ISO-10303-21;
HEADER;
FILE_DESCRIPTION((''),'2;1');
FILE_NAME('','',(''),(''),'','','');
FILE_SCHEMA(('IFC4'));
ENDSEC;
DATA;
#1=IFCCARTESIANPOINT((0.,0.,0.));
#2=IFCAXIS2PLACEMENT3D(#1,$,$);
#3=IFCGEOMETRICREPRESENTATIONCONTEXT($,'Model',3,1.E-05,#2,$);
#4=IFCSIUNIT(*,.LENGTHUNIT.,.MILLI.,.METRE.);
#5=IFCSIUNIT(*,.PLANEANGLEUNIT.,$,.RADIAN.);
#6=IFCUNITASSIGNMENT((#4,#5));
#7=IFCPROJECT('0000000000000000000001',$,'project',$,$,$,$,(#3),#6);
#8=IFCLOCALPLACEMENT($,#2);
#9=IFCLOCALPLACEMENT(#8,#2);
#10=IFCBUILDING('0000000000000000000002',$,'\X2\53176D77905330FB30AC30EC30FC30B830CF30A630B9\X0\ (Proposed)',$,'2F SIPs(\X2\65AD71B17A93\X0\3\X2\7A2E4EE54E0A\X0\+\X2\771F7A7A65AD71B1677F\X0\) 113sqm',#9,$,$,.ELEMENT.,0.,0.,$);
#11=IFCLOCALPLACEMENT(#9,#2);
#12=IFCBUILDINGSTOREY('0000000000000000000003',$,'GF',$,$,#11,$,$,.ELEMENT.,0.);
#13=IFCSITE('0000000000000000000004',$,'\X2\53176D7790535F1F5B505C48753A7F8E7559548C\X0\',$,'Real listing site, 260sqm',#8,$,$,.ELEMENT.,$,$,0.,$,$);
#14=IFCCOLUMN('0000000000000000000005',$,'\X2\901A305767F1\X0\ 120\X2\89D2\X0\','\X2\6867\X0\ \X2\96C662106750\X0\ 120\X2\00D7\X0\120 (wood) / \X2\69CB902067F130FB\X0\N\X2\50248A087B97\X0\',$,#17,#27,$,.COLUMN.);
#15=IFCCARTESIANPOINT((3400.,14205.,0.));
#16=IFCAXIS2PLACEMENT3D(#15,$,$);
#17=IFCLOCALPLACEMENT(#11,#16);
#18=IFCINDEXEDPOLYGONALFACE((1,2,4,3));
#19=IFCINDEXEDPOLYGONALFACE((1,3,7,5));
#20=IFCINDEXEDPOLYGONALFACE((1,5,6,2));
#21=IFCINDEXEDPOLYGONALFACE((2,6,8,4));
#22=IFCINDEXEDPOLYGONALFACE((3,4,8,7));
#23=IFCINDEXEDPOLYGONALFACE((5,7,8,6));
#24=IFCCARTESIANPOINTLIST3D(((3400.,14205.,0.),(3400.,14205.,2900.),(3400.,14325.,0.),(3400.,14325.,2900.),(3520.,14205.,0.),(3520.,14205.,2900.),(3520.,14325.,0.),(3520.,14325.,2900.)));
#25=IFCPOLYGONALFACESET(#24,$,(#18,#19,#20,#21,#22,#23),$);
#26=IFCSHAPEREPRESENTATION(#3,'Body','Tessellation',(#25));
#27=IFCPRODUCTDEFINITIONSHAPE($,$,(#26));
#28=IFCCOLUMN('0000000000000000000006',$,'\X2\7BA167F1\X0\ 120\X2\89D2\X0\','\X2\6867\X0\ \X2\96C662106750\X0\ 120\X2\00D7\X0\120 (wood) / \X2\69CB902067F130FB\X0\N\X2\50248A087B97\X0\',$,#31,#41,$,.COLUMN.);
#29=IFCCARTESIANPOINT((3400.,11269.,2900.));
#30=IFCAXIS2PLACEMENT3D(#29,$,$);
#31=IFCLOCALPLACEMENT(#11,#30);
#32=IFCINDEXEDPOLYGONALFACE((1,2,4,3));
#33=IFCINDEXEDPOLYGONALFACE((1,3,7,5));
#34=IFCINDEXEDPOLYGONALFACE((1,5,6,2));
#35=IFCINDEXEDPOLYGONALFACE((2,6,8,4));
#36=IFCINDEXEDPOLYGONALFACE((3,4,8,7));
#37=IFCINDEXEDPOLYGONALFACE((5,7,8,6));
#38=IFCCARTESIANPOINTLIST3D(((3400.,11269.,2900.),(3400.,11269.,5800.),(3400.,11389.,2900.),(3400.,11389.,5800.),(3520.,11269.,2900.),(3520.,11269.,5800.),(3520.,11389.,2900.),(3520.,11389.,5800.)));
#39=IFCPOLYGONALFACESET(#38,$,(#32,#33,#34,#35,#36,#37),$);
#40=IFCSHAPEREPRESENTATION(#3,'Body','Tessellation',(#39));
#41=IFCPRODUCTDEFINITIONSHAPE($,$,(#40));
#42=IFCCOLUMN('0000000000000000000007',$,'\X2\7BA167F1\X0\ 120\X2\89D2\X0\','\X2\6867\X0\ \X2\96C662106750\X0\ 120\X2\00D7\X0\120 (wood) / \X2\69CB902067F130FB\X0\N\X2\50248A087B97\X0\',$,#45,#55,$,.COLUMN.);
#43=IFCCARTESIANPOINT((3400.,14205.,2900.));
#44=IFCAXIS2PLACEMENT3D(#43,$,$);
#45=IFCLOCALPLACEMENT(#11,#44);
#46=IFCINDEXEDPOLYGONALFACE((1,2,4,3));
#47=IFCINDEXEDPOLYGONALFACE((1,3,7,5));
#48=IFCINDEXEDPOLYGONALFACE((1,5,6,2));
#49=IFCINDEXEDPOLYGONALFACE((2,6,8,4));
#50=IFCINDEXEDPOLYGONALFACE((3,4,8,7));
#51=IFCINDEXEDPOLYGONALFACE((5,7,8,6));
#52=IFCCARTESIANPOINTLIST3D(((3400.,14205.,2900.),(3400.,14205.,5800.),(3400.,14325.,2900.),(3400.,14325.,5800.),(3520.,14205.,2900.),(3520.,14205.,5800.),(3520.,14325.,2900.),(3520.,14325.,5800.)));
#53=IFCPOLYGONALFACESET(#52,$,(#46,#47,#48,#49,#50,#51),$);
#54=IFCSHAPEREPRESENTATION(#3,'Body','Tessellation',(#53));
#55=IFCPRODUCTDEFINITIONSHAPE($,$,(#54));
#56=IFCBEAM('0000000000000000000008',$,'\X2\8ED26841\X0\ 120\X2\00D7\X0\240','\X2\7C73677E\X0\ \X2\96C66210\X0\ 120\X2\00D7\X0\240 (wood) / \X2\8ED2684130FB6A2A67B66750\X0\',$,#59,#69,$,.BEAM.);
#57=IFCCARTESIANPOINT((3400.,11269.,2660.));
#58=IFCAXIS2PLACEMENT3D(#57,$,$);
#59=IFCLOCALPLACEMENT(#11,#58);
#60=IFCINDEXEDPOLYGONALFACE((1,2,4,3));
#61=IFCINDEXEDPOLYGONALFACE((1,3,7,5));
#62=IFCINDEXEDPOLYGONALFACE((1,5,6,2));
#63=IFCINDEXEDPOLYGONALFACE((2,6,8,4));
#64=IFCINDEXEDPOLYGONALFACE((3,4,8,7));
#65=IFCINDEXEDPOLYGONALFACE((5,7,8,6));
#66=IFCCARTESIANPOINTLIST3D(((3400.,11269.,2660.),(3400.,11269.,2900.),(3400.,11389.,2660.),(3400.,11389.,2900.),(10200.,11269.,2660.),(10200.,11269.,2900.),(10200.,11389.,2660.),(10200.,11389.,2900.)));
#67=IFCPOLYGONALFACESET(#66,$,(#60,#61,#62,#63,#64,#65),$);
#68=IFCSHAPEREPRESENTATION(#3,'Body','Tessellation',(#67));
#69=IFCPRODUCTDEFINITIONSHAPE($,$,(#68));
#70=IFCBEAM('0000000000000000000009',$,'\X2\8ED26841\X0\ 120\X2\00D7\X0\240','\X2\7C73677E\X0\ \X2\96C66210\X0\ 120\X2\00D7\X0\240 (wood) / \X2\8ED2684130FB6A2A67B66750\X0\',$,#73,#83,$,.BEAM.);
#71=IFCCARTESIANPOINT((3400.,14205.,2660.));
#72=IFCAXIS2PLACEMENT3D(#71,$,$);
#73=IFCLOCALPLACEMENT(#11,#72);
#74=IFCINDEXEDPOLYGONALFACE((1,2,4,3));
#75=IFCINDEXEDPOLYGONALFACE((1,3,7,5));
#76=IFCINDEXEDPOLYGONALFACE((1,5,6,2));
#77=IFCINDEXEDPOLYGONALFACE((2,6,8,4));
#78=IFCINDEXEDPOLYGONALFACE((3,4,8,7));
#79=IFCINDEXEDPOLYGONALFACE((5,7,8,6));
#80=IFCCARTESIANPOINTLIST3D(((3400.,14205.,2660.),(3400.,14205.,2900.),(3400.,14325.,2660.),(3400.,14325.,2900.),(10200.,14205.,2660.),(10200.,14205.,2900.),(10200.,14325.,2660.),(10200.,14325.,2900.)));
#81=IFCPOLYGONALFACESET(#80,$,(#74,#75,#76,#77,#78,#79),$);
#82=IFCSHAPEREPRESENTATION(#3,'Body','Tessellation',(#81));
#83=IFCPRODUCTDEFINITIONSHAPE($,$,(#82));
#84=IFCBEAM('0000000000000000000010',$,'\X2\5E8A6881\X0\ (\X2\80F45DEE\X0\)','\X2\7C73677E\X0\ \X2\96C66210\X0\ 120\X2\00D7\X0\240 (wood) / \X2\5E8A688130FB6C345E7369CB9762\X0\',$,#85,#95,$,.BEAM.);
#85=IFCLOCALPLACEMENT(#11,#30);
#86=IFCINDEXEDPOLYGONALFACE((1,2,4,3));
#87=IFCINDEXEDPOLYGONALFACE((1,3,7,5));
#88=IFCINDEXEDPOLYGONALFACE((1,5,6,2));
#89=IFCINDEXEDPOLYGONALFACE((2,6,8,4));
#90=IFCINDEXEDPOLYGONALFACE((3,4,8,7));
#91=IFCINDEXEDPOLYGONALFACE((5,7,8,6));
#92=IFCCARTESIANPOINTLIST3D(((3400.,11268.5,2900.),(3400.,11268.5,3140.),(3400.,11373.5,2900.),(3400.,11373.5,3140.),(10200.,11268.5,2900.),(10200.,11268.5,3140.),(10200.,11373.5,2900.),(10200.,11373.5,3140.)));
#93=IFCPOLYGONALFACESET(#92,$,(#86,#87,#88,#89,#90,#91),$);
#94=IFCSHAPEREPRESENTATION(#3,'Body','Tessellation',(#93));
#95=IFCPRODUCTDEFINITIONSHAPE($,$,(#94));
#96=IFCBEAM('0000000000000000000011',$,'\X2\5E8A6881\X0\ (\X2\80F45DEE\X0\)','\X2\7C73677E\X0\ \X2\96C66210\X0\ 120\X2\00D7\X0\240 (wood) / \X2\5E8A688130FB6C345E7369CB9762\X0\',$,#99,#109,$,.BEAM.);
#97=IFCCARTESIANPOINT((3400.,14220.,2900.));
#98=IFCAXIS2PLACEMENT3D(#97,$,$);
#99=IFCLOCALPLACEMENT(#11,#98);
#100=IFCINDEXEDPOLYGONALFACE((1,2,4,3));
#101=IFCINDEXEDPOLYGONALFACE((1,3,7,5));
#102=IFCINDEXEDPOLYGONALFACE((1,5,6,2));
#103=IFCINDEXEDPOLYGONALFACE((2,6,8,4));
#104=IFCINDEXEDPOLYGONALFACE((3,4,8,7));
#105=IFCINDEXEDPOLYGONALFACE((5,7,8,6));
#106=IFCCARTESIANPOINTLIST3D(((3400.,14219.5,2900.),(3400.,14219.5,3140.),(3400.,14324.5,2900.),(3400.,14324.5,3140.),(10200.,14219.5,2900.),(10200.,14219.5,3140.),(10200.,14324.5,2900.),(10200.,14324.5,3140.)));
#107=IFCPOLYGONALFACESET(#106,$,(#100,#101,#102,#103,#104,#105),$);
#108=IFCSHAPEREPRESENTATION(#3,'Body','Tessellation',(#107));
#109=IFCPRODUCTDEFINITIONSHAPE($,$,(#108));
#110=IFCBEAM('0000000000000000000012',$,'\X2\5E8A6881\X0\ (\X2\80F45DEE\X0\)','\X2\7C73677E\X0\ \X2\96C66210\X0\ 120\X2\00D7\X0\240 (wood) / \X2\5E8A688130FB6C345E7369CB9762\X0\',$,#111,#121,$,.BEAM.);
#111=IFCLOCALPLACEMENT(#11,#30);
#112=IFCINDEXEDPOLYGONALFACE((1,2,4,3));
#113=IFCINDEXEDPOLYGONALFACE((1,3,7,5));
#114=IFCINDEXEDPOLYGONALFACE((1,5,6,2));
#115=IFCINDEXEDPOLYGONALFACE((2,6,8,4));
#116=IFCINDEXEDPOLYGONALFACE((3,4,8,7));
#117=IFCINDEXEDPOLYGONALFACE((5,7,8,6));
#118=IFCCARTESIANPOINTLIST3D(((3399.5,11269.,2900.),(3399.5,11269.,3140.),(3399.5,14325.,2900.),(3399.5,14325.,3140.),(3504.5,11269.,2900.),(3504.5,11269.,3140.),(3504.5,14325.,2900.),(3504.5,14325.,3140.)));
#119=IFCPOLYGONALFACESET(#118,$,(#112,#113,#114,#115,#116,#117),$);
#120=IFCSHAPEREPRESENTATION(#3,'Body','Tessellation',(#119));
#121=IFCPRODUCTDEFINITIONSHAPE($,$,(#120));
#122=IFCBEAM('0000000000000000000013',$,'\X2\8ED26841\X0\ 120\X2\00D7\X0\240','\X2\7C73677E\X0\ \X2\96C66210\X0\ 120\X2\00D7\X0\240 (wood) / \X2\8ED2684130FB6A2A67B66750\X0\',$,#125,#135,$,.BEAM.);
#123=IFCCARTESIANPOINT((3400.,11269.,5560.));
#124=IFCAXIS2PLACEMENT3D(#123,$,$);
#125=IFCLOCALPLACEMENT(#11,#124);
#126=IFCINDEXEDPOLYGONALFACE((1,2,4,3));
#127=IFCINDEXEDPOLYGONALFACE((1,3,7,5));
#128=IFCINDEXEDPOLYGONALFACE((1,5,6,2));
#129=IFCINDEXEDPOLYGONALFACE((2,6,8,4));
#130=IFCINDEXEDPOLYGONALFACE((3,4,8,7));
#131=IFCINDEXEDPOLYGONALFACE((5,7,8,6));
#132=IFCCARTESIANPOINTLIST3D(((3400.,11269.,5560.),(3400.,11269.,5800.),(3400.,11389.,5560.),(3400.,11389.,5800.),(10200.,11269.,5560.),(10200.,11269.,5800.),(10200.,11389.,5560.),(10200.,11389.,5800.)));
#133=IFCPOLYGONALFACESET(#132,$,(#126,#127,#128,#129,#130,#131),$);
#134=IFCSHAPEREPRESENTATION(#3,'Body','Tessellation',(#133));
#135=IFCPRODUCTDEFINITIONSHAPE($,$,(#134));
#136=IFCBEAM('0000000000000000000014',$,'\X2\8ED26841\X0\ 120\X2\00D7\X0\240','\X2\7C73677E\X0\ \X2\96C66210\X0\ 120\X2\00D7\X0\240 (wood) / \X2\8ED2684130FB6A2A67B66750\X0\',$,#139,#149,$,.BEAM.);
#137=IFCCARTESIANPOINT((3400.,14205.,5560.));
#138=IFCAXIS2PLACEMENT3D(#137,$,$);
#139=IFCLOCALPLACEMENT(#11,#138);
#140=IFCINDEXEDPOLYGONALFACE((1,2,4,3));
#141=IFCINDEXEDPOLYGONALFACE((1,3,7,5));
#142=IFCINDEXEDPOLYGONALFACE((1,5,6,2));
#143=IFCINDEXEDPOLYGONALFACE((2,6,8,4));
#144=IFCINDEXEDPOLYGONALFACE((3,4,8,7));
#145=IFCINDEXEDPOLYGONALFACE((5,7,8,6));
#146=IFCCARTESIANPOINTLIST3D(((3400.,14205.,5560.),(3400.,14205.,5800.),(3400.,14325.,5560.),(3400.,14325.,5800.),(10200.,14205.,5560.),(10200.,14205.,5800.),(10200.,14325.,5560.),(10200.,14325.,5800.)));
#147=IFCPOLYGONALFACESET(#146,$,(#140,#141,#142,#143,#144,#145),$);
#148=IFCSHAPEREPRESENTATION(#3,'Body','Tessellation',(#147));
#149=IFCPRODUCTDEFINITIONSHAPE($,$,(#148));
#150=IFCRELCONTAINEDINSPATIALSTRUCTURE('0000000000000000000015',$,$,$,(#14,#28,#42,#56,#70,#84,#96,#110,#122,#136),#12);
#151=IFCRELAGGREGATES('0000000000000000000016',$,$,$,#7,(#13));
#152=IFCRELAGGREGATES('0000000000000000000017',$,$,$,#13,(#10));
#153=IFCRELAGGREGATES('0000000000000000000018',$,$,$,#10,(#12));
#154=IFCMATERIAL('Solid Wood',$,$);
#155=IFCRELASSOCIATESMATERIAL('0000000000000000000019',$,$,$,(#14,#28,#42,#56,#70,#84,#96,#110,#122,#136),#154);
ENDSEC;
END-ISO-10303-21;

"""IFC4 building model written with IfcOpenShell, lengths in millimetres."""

from ifc_helpers import new_model, si_unit, frame, frame_2d, origin, place, context, project, spatial, rectangle, extrude, material, element, save


model = new_model("IFC4")

# Units and contexts
model_context = context("Model", 3, precision=1e-05, world=origin())
ifc_project = project(units=[si_unit("LENGTHUNIT", "METRE", prefix="MILLI"), si_unit("PLANEANGLEUNIT", "RADIAN")], contexts=[model_context])

# Site, building, storey
site_placement = place(None, origin())
site = spatial("IfcSite", under=ifc_project, at=site_placement, Name="北海道弟子屈町美留和", ObjectType="Real listing site, 260sqm", CompositionType="ELEMENT", RefElevation=0.0)
building_placement = place(site_placement, origin())
building = spatial("IfcBuilding", under=site, at=building_placement, Name="北海道・ガレージハウス (Proposed)", ObjectType="2F SIPs(断熱窓3種以上+真空断熱板) 113sqm", CompositionType="ELEMENT", ElevationOfRefHeight=0.0, ElevationOfTerrain=0.0)
storey_placement = place(building_placement, origin())
storey = spatial("IfcBuildingStorey", under=building, at=storey_placement, Name="GF", CompositionType="ELEMENT", Elevation=0.0)

# Columns
ifc_material_1 = material(Name="Solid Wood")
column_1_placement = place(storey_placement, frame((3400.0, 14205.0, 0.0)))
element("IfcColumn", 1, at=column_1_placement, inside=storey, material=ifc_material_1, Name="通し柱 120角", Description="桧 集成材 120×120 (wood) / 構造柱・N値計算", PredefinedType="COLUMN", context=model_context, shape_type="SweptSolid", body=[
    extrude(rectangle(XDim=120.0, YDim=120.0, at=frame_2d((60.0, 60.0))), frame((3400.0, 14205.0, 0.0)), (0.0, 0.0, 1.0), 2900.0),
])
column_2_placement = place(storey_placement, frame((3400.0, 11269.0, 2900.0)))
element("IfcColumn", 2, at=column_2_placement, inside=storey, material=ifc_material_1, Name="管柱 120角", Description="桧 集成材 120×120 (wood) / 構造柱・N値計算", PredefinedType="COLUMN", context=model_context, shape_type="SweptSolid", body=[
    extrude(rectangle(XDim=120.0, YDim=120.0, at=frame_2d((60.0, 60.0))), frame((3400.0, 11269.0, 2900.0)), (0.0, 0.0, 1.0), 2900.0),
])
column_3_placement = place(storey_placement, frame((3400.0, 14205.0, 2900.0)))
element("IfcColumn", 3, at=column_3_placement, inside=storey, material=ifc_material_1, Name="管柱 120角", Description="桧 集成材 120×120 (wood) / 構造柱・N値計算", PredefinedType="COLUMN", context=model_context, shape_type="SweptSolid", body=[
    extrude(rectangle(XDim=120.0, YDim=120.0, at=frame_2d((60.0, 60.0))), frame((3400.0, 14205.0, 2900.0)), (0.0, 0.0, 1.0), 2900.0),
])

# Beams
beam_1_placement = place(storey_placement, frame((3400.0, 11269.0, 2660.0)))
element("IfcBeam", 4, at=beam_1_placement, inside=storey, material=ifc_material_1, Name="軒桁 120×240", Description="米松 集成 120×240 (wood) / 軒桁・横架材", PredefinedType="BEAM", context=model_context, shape_type="SweptSolid", body=[
    extrude(rectangle(XDim=6800.0, YDim=120.0, at=frame_2d((3400.0, 60.0))), frame((3400.0, 11269.0, 2660.0)), (0.0, 0.0, 1.0), 240.0),
])
beam_2_placement = place(storey_placement, frame((3400.0, 14205.0, 2660.0)))
element("IfcBeam", 5, at=beam_2_placement, inside=storey, material=ifc_material_1, Name="軒桁 120×240", Description="米松 集成 120×240 (wood) / 軒桁・横架材", PredefinedType="BEAM", context=model_context, shape_type="SweptSolid", body=[
    extrude(rectangle(XDim=6800.0, YDim=120.0, at=frame_2d((3400.0, 60.0))), frame((3400.0, 14205.0, 2660.0)), (0.0, 0.0, 1.0), 240.0),
])
beam_3_placement = place(storey_placement, frame((3400.0, 11269.0, 2900.0)))
element("IfcBeam", 6, at=beam_3_placement, inside=storey, material=ifc_material_1, Name="床梁 (胴差)", Description="米松 集成 120×240 (wood) / 床梁・水平構面", PredefinedType="BEAM", context=model_context, shape_type="SweptSolid", body=[
    extrude(rectangle(XDim=6800.0, YDim=105.0, at=frame_2d((3400.0, 52.0))), frame((3400.0, 11269.0, 2900.0)), (0.0, 0.0, 1.0), 240.0),
])
beam_4_placement = place(storey_placement, frame((3400.0, 14220.0, 2900.0)))
element("IfcBeam", 7, at=beam_4_placement, inside=storey, material=ifc_material_1, Name="床梁 (胴差)", Description="米松 集成 120×240 (wood) / 床梁・水平構面", PredefinedType="BEAM", context=model_context, shape_type="SweptSolid", body=[
    extrude(rectangle(XDim=6800.0, YDim=105.0, at=frame_2d((3400.0, 52.0))), frame((3400.0, 14220.0, 2900.0)), (0.0, 0.0, 1.0), 240.0),
])
beam_5_placement = place(storey_placement, frame((3400.0, 11269.0, 2900.0)))
element("IfcBeam", 8, at=beam_5_placement, inside=storey, material=ifc_material_1, Name="床梁 (胴差)", Description="米松 集成 120×240 (wood) / 床梁・水平構面", PredefinedType="BEAM", context=model_context, shape_type="SweptSolid", body=[
    extrude(rectangle(XDim=105.0, YDim=3056.0, at=frame_2d((52.0, 1528.0))), frame((3400.0, 11269.0, 2900.0)), (0.0, 0.0, 1.0), 240.0),
])
beam_6_placement = place(storey_placement, frame((3400.0, 11269.0, 5560.0)))
element("IfcBeam", 9, at=beam_6_placement, inside=storey, material=ifc_material_1, Name="軒桁 120×240", Description="米松 集成 120×240 (wood) / 軒桁・横架材", PredefinedType="BEAM", context=model_context, shape_type="SweptSolid", body=[
    extrude(rectangle(XDim=6800.0, YDim=120.0, at=frame_2d((3400.0, 60.0))), frame((3400.0, 11269.0, 5560.0)), (0.0, 0.0, 1.0), 240.0),
])
beam_7_placement = place(storey_placement, frame((3400.0, 14205.0, 5560.0)))
element("IfcBeam", 10, at=beam_7_placement, inside=storey, material=ifc_material_1, Name="軒桁 120×240", Description="米松 集成 120×240 (wood) / 軒桁・横架材", PredefinedType="BEAM", context=model_context, shape_type="SweptSolid", body=[
    extrude(rectangle(XDim=6800.0, YDim=120.0, at=frame_2d((3400.0, 60.0))), frame((3400.0, 14205.0, 5560.0)), (0.0, 0.0, 1.0), 240.0),
])

save(model, "model.ifc")
